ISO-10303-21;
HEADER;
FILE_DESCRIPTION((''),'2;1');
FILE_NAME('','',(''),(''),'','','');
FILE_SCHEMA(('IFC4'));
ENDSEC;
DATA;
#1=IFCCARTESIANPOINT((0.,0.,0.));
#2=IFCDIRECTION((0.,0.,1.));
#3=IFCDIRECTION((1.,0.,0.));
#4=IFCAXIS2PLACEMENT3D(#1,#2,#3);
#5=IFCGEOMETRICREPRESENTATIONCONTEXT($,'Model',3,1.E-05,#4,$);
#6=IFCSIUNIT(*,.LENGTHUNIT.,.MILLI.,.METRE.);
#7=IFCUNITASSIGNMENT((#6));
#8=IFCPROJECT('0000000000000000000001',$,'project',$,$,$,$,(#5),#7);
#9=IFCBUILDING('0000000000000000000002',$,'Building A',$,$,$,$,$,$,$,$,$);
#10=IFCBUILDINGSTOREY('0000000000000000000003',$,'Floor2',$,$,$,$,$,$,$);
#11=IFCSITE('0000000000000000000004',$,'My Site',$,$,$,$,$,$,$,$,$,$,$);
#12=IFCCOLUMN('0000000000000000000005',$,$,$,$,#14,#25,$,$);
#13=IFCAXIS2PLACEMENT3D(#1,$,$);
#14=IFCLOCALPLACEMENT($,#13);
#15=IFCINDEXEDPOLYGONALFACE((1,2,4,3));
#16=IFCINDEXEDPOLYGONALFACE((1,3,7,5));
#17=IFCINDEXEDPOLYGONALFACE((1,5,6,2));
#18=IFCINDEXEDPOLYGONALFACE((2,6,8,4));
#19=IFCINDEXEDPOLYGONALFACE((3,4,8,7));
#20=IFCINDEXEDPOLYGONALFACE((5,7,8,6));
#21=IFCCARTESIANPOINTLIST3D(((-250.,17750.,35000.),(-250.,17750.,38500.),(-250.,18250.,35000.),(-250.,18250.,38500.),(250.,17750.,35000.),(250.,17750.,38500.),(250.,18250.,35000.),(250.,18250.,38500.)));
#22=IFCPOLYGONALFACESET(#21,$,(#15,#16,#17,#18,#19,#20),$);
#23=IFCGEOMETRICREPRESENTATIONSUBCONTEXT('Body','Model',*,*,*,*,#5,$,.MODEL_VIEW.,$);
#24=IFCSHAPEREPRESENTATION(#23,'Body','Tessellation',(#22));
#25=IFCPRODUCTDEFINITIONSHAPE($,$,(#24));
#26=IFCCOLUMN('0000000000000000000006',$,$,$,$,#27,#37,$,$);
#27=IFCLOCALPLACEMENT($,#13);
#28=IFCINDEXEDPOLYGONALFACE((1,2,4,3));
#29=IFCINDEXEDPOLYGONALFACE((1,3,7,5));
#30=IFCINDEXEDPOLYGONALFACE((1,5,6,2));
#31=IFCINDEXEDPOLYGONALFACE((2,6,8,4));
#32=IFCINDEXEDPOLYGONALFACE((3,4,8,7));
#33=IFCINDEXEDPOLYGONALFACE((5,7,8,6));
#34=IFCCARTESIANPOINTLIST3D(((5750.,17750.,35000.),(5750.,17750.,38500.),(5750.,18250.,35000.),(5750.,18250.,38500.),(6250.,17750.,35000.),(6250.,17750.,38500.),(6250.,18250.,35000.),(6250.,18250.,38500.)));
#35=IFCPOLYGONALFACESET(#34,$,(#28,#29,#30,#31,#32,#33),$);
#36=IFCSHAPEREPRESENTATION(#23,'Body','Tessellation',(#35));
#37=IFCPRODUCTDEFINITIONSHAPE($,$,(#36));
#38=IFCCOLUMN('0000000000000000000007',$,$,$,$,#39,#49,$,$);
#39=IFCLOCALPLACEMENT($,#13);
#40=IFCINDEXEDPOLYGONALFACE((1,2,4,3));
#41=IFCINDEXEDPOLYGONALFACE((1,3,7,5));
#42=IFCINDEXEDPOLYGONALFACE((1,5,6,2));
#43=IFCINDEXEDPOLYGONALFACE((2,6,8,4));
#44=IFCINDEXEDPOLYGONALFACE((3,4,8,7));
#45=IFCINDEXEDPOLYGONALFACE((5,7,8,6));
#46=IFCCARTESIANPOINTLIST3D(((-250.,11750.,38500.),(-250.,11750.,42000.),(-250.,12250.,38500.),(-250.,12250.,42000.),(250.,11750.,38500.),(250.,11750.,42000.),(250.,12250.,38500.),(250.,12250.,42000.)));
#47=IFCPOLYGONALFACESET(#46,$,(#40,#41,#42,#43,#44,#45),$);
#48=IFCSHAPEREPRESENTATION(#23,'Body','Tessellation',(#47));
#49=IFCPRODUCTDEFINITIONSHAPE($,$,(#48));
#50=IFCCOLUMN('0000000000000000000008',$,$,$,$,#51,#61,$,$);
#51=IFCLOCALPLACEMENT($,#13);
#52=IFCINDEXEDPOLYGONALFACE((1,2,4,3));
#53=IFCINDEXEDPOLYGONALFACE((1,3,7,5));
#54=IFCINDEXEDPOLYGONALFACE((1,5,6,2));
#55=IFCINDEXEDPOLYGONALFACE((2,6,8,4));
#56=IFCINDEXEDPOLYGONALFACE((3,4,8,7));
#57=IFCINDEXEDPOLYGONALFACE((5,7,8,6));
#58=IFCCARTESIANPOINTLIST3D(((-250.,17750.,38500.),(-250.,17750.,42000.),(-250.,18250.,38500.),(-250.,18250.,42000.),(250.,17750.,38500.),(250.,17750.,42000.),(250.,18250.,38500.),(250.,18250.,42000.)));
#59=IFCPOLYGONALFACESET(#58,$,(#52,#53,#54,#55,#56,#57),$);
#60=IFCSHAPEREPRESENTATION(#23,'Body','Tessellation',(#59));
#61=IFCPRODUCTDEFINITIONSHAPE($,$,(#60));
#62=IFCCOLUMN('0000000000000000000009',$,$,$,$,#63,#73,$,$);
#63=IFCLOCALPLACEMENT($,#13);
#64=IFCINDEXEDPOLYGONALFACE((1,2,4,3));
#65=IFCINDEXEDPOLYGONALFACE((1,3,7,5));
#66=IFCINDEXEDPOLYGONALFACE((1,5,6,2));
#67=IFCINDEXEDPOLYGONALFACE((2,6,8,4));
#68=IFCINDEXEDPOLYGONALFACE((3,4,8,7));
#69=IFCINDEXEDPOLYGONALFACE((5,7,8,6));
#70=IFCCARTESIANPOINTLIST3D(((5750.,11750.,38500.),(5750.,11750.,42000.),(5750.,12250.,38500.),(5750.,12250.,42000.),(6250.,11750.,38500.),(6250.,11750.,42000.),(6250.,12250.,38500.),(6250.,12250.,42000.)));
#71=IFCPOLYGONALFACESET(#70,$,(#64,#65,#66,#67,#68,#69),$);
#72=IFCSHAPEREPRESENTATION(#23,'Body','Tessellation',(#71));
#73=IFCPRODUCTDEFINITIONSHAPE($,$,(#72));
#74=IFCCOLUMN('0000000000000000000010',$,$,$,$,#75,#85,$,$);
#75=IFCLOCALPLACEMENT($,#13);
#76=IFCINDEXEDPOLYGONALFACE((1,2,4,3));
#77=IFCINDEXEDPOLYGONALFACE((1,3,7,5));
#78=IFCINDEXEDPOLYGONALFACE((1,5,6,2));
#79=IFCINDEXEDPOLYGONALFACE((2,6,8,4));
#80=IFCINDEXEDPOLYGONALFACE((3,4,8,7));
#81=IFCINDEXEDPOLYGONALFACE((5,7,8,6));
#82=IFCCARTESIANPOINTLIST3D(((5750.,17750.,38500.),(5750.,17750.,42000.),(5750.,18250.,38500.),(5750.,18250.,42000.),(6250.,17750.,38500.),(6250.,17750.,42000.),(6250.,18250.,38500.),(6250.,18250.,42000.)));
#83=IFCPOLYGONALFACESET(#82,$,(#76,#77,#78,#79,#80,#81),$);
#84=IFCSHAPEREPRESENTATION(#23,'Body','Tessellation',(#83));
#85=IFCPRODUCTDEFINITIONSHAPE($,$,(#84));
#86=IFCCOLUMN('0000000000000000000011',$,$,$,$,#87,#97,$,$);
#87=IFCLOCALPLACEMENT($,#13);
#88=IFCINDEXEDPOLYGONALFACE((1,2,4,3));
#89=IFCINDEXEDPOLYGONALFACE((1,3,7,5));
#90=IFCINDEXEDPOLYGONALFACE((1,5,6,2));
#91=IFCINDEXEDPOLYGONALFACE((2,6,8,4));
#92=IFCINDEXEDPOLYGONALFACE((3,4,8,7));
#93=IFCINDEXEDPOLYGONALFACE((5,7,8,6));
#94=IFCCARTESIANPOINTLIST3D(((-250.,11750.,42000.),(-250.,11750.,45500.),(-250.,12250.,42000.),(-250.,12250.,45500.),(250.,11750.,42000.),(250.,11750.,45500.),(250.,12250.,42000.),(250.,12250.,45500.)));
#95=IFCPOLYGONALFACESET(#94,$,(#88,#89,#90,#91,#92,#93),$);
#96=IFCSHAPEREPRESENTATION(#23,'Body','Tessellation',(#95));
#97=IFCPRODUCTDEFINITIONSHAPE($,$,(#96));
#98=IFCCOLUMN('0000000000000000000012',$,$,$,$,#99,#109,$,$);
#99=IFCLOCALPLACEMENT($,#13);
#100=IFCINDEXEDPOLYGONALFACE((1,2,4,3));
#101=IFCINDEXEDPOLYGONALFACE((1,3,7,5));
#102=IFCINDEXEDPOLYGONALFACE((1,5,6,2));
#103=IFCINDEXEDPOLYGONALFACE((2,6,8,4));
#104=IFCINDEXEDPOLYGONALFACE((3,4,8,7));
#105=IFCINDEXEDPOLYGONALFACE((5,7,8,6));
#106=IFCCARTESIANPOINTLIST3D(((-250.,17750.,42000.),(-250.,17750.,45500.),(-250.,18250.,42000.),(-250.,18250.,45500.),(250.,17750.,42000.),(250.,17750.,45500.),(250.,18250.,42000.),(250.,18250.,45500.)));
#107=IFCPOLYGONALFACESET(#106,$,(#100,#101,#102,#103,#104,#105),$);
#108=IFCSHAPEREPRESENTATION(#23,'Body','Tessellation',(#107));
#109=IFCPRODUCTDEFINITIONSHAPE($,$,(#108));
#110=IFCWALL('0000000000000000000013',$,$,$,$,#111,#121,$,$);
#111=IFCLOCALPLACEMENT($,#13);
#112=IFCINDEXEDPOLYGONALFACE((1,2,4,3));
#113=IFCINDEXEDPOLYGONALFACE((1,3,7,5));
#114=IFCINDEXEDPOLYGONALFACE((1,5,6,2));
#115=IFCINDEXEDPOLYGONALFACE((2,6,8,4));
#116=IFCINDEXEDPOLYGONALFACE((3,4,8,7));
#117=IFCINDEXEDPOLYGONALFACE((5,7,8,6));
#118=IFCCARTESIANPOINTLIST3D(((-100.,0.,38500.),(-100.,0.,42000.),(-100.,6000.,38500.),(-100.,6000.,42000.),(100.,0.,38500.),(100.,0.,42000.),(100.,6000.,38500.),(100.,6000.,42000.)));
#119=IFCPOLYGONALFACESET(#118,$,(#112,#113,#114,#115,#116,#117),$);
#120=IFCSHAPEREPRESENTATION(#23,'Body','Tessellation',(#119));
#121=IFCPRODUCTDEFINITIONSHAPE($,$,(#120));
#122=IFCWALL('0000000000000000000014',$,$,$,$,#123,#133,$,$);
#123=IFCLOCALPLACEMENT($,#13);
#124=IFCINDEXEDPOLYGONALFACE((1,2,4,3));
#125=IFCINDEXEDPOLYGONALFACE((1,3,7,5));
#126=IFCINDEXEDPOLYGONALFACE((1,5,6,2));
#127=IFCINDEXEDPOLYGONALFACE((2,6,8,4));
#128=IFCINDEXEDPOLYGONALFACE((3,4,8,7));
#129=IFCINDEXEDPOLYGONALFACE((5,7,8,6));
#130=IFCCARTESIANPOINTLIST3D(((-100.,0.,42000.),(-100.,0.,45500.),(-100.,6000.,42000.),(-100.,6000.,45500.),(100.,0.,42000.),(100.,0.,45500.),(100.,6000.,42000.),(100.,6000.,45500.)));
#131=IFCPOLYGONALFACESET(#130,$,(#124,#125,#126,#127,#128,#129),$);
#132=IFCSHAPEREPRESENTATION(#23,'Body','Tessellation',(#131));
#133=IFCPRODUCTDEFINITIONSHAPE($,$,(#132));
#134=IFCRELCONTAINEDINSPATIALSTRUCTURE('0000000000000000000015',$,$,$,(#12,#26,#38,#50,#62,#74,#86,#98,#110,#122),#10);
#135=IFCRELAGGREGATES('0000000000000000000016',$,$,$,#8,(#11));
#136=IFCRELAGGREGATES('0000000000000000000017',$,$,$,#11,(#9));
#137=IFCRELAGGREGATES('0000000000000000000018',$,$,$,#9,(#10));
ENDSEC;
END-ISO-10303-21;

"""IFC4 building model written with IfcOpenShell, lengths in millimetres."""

from ifc_helpers import new_model, si_unit, frame, origin_with_axes, place, context, subcontext, project, spatial, line, indexed_curve, outline, extrude, element, save


model = new_model("IFC4")

# Units and contexts
model_context = context("Model", 3, precision=1e-05, world=origin_with_axes())
body_context = subcontext(model_context, "Body", "Model", "MODEL_VIEW")
ifc_project = project(units=[si_unit("LENGTHUNIT", "METRE", prefix="MILLI")], contexts=[model_context])

# Site, building, storey
site = spatial("IfcSite", under=ifc_project, Name="My Site")
building = spatial("IfcBuilding", under=site, Name="Building A")
storey = spatial("IfcBuildingStorey", under=building, Name="Floor2")

# Columns
for number, where, z_axis, x_axis in (
    (1, (0.0, 18000.0, 35000.0), (0.0, 0.0, 1.0), (1.0, 0.0, 0.0)),
    (2, (6000.0, 18000.0, 35000.0), (0.0, 0.0, 1.0), (1.0, 0.0, 0.0)),
    (3, (0.0, 12000.0, 38500.0), (0.0, 0.0, 1.0), (1.0, 0.0, 0.0)),
    (4, (0.0, 18000.0, 38500.0), (0.0, 0.0, 1.0), (1.0, 0.0, 0.0)),
    (5, (6000.0, 12000.0, 38500.0), (0.0, 0.0, 1.0), (1.0, 0.0, 0.0)),
    (6, (6000.0, 18000.0, 38500.0), (0.0, 0.0, 1.0), (1.0, 0.0, 0.0)),
    (7, (0.0, 12000.0, 42000.0), (0.0, 0.0, 1.0), (1.0, 0.0, 0.0)),
    (8, (0.0, 18000.0, 42000.0), (0.0, 0.0, 1.0), (1.0, 0.0, 0.0)),
):
    element("IfcColumn", number, at=place(None, frame(where, z_axis=z_axis, x_axis=x_axis)), inside=storey, context=body_context, shape_type="SweptSolid", body=[
        extrude(outline(indexed_curve([(-250.0, -250.0), (250.0, -250.0), (250.0, 250.0), (-250.0, 250.0)], segments=[line(1, 2, 3, 4, 1)])), origin_with_axes(), (0.0, 0.0, 1.0), 3500.0),
    ])

# Walls
for number, where, z_axis, x_axis in (
    (9, (-100.0, 6000.0, 38500.0), (0.0, 0.0, 1.0), (0.0, -1.0, 0.0)),
    (10, (-100.0, 6000.0, 42000.0), (0.0, 0.0, 1.0), (0.0, -1.0, 0.0)),
):
    element("IfcWall", number, at=place(None, frame(where, z_axis=z_axis, x_axis=x_axis)), inside=storey, context=body_context, shape_type="SweptSolid", body=[
        extrude(outline(indexed_curve([(0.0, 0.0), (0.0, 200.0), (6000.0, 200.0), (6000.0, 0.0), (0.0, 0.0)], self_intersect=False)), origin_with_axes(), (0.0, 0.0, 1.0), 3500.0),
    ])

save(model, "model.ifc")
